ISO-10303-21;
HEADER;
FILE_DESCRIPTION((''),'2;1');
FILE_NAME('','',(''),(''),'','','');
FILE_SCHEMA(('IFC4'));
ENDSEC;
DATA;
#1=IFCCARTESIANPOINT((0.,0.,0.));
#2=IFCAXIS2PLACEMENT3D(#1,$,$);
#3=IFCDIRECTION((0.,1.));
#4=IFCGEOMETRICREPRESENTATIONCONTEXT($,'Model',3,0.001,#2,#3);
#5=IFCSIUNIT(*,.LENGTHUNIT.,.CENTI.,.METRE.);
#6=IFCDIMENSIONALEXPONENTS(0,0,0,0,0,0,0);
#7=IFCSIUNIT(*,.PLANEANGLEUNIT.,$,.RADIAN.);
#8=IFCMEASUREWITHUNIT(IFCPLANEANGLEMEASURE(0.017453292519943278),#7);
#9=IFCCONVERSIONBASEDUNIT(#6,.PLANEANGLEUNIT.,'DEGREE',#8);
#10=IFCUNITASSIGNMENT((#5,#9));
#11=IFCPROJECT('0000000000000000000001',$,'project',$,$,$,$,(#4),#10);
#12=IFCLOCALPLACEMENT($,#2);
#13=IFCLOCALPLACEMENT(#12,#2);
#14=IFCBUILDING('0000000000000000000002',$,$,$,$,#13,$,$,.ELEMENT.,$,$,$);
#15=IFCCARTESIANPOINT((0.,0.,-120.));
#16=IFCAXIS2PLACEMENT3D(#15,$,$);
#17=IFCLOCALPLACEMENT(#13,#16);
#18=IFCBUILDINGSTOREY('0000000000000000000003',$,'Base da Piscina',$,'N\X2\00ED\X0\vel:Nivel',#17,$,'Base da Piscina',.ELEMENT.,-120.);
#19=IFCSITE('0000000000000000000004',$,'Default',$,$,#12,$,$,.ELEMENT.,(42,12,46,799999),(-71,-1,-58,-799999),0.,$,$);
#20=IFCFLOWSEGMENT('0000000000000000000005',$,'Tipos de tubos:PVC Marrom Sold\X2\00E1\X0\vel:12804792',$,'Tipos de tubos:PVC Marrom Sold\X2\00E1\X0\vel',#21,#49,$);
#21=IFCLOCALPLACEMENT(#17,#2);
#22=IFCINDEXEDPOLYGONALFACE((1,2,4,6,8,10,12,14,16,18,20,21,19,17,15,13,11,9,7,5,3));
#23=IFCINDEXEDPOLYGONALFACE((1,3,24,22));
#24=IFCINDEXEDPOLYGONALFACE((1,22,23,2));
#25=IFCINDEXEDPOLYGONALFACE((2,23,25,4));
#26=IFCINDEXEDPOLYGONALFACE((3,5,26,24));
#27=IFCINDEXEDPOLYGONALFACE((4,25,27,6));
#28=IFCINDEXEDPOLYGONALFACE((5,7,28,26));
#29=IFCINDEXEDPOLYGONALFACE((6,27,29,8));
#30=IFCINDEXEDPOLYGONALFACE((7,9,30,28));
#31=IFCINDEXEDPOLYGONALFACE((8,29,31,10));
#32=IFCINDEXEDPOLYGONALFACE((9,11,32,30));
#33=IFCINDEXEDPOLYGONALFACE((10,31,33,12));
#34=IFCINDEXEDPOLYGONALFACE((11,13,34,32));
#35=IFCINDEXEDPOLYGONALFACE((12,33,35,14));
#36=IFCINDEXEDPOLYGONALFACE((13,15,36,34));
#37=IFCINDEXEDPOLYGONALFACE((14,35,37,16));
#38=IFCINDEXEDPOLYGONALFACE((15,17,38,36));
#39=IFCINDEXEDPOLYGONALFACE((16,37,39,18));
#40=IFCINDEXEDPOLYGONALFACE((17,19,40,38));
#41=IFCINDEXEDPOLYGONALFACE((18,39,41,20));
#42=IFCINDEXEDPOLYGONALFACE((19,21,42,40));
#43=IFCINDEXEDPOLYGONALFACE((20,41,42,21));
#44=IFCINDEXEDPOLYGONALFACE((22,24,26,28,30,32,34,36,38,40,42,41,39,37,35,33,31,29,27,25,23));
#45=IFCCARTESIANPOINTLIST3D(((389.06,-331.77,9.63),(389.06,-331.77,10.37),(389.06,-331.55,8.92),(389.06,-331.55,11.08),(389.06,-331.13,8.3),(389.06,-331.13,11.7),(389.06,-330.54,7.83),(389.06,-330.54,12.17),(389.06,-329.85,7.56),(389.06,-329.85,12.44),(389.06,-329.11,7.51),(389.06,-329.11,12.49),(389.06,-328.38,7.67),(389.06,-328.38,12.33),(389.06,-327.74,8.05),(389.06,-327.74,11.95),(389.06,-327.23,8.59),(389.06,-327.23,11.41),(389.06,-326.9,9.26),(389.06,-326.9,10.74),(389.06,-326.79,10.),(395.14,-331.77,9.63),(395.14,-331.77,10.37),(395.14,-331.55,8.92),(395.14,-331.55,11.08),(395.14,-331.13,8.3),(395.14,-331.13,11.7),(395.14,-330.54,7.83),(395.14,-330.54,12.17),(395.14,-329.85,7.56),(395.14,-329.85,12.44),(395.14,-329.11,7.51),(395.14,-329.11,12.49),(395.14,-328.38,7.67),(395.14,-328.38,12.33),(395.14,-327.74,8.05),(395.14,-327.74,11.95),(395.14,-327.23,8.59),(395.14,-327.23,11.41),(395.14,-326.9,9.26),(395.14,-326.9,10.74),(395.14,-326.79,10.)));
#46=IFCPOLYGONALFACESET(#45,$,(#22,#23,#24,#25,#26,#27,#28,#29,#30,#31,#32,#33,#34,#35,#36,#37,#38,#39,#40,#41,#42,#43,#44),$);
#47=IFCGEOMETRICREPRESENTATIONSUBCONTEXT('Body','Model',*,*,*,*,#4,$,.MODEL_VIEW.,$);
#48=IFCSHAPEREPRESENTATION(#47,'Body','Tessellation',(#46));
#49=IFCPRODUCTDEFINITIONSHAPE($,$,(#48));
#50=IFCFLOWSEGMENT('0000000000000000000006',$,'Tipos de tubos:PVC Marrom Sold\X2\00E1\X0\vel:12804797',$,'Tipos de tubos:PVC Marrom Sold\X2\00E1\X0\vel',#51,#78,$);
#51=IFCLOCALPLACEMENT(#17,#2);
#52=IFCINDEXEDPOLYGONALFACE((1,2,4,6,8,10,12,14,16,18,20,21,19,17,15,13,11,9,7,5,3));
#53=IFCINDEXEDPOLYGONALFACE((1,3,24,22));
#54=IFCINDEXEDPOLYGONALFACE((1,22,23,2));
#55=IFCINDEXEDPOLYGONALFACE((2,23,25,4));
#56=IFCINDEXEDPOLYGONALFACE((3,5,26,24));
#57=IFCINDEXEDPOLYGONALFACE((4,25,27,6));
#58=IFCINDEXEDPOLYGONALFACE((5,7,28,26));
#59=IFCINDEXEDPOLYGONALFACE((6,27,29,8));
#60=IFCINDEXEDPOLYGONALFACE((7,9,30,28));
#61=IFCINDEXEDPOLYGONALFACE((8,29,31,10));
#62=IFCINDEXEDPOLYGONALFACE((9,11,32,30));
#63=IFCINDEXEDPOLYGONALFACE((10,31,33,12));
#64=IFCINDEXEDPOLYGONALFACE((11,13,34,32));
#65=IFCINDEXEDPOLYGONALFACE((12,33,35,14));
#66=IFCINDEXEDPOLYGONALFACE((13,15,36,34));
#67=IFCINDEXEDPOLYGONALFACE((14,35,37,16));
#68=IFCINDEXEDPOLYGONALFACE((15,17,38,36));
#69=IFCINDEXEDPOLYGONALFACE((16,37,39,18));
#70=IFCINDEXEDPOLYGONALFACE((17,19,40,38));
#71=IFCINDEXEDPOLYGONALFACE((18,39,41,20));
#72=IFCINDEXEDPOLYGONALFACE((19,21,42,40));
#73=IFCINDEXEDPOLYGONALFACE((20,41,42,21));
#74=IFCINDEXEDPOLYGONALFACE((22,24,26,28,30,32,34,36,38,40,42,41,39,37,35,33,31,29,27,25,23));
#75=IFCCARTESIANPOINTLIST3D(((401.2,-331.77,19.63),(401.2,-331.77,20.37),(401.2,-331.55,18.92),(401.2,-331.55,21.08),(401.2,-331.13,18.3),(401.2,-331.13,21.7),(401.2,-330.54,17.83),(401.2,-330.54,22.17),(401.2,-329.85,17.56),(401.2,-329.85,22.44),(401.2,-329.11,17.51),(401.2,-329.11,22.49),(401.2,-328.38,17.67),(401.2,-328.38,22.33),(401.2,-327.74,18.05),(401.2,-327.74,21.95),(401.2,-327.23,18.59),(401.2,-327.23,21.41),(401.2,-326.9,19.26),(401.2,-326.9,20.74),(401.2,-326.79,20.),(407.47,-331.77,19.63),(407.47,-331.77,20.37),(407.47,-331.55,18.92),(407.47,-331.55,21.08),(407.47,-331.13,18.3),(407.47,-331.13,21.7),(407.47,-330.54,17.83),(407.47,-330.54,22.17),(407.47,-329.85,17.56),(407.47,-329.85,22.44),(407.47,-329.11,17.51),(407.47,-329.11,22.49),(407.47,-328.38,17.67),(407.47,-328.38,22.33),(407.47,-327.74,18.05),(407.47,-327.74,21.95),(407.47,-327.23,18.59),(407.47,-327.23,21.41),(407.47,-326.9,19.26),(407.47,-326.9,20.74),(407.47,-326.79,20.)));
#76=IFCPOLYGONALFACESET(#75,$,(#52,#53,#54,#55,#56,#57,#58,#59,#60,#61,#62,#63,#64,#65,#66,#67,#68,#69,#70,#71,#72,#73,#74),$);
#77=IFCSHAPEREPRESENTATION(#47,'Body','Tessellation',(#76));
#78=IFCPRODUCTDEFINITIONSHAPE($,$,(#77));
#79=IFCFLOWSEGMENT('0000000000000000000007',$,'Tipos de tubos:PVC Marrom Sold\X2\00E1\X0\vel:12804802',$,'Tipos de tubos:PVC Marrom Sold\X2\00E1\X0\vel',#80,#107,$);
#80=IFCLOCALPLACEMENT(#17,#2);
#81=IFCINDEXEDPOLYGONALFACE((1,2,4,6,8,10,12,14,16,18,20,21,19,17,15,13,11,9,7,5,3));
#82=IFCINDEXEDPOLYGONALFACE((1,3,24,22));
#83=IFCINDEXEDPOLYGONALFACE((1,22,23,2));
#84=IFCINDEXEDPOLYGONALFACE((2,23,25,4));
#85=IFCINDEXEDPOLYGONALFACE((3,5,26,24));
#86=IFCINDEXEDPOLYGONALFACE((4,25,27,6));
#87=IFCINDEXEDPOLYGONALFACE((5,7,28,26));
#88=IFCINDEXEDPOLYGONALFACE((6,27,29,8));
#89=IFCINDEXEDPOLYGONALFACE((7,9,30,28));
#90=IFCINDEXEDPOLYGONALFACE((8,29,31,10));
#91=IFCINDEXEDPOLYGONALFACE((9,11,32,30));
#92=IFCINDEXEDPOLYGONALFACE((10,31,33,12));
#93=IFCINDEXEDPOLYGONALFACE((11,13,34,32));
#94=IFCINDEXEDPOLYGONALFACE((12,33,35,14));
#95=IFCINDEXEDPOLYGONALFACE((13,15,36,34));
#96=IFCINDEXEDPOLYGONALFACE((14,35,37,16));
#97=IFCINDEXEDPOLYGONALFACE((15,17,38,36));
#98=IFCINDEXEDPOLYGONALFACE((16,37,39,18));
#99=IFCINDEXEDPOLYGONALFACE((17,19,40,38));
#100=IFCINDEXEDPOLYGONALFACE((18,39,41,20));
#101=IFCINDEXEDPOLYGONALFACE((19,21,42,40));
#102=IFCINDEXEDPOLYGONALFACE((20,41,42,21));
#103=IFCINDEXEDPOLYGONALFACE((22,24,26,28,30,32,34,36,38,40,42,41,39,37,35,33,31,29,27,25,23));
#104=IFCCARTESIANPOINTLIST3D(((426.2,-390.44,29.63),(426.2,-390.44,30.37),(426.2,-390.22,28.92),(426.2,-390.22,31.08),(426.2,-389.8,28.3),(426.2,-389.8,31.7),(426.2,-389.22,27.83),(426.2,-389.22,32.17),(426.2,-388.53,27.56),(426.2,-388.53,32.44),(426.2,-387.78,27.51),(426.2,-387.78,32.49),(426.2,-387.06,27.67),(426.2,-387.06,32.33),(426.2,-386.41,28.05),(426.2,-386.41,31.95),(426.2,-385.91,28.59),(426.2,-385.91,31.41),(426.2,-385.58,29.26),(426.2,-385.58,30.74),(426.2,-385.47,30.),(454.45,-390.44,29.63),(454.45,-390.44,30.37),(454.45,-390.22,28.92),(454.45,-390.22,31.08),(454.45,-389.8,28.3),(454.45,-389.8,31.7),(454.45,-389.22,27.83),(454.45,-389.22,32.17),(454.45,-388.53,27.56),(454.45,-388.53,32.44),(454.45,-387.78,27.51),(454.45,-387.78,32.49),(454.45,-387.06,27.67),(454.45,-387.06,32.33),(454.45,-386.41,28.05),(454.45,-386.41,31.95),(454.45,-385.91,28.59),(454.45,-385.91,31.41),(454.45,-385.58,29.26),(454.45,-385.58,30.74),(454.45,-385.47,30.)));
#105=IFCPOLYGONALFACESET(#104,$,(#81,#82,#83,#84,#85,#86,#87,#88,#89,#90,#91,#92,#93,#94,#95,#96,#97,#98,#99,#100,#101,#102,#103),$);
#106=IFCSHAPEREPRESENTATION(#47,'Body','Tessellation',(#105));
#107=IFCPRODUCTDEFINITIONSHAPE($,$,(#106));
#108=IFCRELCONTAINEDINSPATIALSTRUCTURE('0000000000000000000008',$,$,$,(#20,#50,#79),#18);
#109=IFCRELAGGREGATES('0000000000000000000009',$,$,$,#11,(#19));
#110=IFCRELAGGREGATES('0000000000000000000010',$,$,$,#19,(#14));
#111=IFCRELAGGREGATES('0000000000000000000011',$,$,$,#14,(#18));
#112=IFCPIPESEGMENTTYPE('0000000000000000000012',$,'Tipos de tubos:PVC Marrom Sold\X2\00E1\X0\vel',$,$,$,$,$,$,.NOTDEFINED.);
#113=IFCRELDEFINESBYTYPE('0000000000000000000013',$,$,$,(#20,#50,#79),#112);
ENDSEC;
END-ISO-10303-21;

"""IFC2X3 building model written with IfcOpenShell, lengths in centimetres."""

from ifc_helpers import new_model, entity, si_unit, converted_unit, direction, frame, frame_2d, origin, place, context, subcontext, project, spatial, circle, extrude, type_object, element, save


model = new_model("IFC2X3")

# Units and contexts
model_context = context("Model", 3, precision=0.001, world=origin(), true_north=direction((0.0, 1.0)))
body_context = subcontext(model_context, "Body", "Model", "MODEL_VIEW")
ifc_project = project(units=[si_unit("LENGTHUNIT", "METRE", prefix="CENTI"), converted_unit("PLANEANGLEUNIT", "DEGREE", entity("IfcPlaneAngleMeasure", 0.017453292519943278), si_unit("PLANEANGLEUNIT", "RADIAN"), dimensions=[0, 0, 0, 0, 0, 0, 0])], contexts=[model_context])

# Site, building, storey
site_placement = place(None, origin())
site = spatial("IfcSite", under=ifc_project, at=site_placement, Name="Default", CompositionType="ELEMENT", RefLatitude=(42, 12, 46, 799999), RefLongitude=(-71, -1, -58, -799999), RefElevation=0.0)
building_placement = place(site_placement, origin())
building = spatial("IfcBuilding", under=site, at=building_placement, CompositionType="ELEMENT")
storey_placement = place(building_placement, frame((0.0, 0.0, -120.0)))
storey = spatial("IfcBuildingStorey", under=building, at=storey_placement, Name="Base da Piscina", ObjectType="Nível:Nivel", LongName="Base da Piscina", CompositionType="ELEMENT", Elevation=-120.0)

# Flow segments
pipe_segment_type = type_object("IfcPipeSegmentType", Name="Tipos de tubos:PVC Marrom Soldável", PredefinedType="NOTDEFINED")
flow_segment_1_placement = place(storey_placement, origin())
element("IfcFlowSegment", 1, at=flow_segment_1_placement, inside=storey, type_object=pipe_segment_type, Name="Tipos de tubos:PVC Marrom Soldável:12804792", ObjectType="Tipos de tubos:PVC Marrom Soldável", context=body_context, shape_type="SweptSolid", body=[
    extrude(circle(Radius=2.5, at=frame_2d((0.0, 0.0), x_axis=(1.0, 0.0))), frame((389.06, -329.29, 10.0), z_axis=(1.0, 0.0, 0.0), x_axis=(0.0, 1.0, 0.0)), (0.0, 0.0, 1.0), 6.08),
])
flow_segment_2_placement = place(storey_placement, origin())
element("IfcFlowSegment", 2, at=flow_segment_2_placement, inside=storey, type_object=pipe_segment_type, Name="Tipos de tubos:PVC Marrom Soldável:12804797", ObjectType="Tipos de tubos:PVC Marrom Soldável", context=body_context, shape_type="SweptSolid", body=[
    extrude(circle(Radius=2.5, at=frame_2d((0.0, 0.0), x_axis=(1.0, 0.0))), frame((401.2, -329.29, 20.0), z_axis=(1.0, 0.0, 0.0), x_axis=(0.0, 1.0, 0.0)), (0.0, 0.0, 1.0), 6.27),
])
flow_segment_3_placement = place(storey_placement, origin())
element("IfcFlowSegment", 3, at=flow_segment_3_placement, inside=storey, type_object=pipe_segment_type, Name="Tipos de tubos:PVC Marrom Soldável:12804802", ObjectType="Tipos de tubos:PVC Marrom Soldável", context=body_context, shape_type="SweptSolid", body=[
    extrude(circle(Radius=2.5, at=frame_2d((0.0, 0.0), x_axis=(1.0, 0.0))), frame((426.2, -387.97, 30.0), z_axis=(1.0, 0.0, 0.0), x_axis=(0.0, 1.0, 0.0)), (0.0, 0.0, 1.0), 28.25),
])

save(model, "model.ifc")
